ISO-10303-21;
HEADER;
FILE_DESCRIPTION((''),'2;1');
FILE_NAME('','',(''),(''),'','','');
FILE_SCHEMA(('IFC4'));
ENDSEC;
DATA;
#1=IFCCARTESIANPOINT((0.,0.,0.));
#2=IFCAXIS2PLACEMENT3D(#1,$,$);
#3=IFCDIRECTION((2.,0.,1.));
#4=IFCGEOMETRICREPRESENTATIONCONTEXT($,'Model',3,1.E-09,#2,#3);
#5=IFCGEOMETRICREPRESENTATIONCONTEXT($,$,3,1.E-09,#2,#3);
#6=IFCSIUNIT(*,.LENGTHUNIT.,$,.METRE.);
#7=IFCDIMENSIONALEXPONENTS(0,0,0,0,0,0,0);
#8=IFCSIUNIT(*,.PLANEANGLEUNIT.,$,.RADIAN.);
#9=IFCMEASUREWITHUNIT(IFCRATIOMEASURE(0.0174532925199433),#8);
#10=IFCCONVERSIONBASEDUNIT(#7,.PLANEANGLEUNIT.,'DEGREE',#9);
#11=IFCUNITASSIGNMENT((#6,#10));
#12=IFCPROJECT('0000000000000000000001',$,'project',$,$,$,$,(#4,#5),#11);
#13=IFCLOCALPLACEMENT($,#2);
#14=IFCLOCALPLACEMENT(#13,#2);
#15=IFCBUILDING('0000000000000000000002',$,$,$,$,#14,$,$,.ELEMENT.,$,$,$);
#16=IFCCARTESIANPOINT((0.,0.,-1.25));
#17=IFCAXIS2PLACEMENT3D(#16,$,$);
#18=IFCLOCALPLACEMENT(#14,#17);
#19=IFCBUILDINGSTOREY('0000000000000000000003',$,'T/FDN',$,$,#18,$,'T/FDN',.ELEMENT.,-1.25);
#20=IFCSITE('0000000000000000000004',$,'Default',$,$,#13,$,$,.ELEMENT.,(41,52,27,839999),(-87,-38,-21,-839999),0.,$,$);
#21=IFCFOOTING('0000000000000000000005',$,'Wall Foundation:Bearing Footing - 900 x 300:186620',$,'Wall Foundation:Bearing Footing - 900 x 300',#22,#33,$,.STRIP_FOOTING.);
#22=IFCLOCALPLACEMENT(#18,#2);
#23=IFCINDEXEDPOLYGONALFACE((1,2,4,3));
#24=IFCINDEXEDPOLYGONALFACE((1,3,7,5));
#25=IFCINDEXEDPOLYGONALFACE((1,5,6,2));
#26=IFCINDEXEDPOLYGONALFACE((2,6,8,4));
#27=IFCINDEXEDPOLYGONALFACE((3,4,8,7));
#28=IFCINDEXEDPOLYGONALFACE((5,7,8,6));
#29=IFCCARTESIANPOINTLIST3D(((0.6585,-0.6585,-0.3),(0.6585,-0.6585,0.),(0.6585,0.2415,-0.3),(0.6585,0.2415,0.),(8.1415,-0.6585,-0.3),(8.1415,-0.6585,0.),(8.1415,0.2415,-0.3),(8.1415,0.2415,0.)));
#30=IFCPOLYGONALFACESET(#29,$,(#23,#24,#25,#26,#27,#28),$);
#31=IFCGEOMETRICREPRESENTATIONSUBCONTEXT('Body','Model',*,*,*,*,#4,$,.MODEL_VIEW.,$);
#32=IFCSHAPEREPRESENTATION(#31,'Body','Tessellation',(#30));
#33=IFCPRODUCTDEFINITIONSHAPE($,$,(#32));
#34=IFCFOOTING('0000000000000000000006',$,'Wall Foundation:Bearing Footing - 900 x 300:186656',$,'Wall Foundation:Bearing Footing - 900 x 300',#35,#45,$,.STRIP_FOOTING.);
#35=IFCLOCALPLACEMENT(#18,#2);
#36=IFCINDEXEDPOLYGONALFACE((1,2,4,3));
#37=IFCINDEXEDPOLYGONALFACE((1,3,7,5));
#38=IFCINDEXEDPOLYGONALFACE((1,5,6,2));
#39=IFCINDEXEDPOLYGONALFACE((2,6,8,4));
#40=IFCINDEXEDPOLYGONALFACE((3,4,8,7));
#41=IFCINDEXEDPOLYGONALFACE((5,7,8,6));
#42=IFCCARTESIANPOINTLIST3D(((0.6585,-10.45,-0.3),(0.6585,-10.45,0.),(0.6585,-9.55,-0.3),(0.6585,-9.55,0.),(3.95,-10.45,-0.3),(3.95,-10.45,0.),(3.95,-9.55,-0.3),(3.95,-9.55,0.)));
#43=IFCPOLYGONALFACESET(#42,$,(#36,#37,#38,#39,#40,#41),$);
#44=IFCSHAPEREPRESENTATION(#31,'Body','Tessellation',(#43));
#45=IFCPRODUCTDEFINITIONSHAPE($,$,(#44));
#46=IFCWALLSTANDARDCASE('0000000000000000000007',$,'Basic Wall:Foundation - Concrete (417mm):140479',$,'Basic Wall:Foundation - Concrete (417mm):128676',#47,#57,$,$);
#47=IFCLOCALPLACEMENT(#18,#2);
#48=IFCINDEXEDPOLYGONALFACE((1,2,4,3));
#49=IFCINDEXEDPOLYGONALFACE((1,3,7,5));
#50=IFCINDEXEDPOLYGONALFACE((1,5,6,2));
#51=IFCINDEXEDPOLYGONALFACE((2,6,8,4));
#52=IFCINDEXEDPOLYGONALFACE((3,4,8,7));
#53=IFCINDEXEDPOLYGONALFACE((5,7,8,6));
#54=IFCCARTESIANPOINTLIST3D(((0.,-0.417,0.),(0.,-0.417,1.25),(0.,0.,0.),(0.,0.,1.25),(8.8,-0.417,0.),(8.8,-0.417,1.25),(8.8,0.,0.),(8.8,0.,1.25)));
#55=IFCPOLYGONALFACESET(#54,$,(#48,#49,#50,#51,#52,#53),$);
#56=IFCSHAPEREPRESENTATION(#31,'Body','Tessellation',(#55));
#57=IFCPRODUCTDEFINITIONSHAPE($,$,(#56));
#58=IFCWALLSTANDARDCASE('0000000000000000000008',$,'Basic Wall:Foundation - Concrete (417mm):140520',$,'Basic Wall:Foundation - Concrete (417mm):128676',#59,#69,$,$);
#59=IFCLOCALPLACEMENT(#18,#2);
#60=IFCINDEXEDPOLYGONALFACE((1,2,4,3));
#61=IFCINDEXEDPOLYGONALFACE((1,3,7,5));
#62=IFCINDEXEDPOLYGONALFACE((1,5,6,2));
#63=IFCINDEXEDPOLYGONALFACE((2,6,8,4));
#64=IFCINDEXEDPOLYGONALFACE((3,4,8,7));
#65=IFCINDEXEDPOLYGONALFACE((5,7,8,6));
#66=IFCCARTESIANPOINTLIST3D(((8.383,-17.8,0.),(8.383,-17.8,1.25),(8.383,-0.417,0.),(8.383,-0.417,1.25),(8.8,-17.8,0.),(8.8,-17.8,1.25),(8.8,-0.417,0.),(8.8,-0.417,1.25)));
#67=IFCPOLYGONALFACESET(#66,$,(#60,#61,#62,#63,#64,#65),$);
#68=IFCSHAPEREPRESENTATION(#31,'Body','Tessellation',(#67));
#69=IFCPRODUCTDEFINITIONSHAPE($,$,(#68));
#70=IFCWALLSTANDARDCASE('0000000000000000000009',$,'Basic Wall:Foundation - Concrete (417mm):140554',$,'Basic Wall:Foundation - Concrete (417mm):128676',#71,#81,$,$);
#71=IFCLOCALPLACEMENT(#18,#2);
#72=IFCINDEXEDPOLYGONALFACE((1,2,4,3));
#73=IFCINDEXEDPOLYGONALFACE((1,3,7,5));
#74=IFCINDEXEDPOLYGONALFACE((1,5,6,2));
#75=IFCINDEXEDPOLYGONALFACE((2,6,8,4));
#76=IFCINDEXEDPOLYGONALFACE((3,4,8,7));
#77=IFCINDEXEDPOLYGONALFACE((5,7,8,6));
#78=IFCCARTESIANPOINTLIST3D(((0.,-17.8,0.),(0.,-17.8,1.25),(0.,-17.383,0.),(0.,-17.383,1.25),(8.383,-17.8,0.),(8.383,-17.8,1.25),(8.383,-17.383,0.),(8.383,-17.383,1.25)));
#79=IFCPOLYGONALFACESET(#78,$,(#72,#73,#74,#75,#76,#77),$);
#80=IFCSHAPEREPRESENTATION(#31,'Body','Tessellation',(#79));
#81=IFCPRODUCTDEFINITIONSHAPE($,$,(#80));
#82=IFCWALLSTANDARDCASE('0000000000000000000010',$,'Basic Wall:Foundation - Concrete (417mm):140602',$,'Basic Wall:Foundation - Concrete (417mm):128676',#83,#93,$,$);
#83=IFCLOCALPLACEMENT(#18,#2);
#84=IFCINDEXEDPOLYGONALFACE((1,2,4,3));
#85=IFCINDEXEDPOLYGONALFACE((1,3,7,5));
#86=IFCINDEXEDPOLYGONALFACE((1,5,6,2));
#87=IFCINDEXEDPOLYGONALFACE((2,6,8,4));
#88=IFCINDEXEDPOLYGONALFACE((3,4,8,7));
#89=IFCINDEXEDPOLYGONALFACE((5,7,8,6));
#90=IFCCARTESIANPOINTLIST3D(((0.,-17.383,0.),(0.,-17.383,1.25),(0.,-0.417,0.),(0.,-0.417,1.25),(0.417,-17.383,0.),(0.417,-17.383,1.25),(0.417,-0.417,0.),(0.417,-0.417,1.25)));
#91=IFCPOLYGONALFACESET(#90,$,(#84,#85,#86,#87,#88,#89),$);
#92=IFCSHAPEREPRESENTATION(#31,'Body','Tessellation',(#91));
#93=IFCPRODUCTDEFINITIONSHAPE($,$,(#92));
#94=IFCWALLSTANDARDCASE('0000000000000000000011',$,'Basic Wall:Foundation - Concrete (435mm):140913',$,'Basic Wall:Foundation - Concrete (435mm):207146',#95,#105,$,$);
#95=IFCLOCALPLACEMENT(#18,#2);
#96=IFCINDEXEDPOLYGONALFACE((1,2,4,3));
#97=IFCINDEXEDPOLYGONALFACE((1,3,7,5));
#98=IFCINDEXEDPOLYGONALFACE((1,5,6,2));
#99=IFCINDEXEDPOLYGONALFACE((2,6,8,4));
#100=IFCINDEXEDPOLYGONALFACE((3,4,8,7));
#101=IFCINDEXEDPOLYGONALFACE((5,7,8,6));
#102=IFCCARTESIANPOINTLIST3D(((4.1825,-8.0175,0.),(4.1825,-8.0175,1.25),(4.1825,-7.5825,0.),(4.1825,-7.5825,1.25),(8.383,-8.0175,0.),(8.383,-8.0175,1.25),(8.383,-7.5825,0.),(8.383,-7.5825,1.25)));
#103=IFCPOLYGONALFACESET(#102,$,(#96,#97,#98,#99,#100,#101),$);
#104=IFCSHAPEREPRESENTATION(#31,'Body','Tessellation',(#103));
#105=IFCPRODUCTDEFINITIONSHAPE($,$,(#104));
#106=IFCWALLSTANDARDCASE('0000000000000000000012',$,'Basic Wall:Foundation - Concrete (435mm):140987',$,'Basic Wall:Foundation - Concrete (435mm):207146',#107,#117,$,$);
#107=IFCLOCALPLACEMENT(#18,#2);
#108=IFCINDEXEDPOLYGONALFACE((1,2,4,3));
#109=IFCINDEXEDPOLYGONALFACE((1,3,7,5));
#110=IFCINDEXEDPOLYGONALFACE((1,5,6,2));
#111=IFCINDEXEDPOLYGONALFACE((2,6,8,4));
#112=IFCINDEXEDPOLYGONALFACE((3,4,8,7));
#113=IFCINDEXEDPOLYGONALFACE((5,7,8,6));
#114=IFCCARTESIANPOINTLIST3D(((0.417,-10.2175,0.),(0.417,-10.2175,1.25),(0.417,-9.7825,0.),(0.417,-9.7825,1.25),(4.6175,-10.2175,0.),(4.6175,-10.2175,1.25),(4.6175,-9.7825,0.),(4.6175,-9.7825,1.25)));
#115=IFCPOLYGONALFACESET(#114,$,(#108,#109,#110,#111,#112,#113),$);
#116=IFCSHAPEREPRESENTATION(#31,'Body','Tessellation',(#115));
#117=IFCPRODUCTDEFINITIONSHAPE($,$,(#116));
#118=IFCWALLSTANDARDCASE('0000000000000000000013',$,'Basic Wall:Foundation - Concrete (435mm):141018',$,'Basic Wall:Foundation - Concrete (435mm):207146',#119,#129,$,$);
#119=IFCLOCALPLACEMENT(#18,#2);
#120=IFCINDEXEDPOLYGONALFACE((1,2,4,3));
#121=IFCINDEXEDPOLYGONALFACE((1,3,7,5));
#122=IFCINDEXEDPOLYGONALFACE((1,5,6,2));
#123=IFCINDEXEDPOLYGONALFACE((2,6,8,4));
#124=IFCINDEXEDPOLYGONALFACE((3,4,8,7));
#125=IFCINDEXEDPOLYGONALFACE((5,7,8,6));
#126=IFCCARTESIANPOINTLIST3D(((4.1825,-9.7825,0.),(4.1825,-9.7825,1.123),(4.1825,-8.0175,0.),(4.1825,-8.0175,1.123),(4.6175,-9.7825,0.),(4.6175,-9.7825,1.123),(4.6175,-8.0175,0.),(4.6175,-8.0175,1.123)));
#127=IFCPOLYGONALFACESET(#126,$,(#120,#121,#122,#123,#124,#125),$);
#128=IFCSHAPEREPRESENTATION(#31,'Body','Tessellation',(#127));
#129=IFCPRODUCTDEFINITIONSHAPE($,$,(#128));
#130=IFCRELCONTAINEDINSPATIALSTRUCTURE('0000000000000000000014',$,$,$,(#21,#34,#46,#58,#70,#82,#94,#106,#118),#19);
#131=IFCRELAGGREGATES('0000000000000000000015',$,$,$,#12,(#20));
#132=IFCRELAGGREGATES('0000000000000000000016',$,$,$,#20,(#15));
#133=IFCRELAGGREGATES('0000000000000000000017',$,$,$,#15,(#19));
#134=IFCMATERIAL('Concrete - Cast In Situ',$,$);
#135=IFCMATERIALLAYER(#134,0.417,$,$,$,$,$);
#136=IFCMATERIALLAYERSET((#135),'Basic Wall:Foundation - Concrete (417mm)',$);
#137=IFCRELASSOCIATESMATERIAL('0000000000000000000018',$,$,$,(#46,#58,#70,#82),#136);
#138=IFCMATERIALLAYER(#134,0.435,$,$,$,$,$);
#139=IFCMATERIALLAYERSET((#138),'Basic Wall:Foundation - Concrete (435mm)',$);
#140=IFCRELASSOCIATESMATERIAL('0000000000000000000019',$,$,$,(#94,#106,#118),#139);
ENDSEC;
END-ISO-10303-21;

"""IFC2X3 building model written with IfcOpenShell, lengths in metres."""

from ifc_helpers import new_model, entity, si_unit, converted_unit, direction, frame, frame_2d, origin, place, context, subcontext, project, spatial, rectangle, extrude, material, layer, layer_set, layer_usage, element, save


model = new_model("IFC2X3")

# Units and contexts
model_context = context("Model", 3, precision=1e-09, world=origin(), true_north=direction((2.0, 0.0, 1.0)))
context_of_model = context(None, 3, precision=1e-09, world=origin(), true_north=direction((2.0, 0.0, 1.0)))
body_context = subcontext(model_context, "Body", "Model", "MODEL_VIEW")
ifc_project = project(units=[si_unit("LENGTHUNIT", "METRE"), converted_unit("PLANEANGLEUNIT", "DEGREE", entity("IfcRatioMeasure", 0.0174532925199433), si_unit("PLANEANGLEUNIT", "RADIAN"), dimensions=[0, 0, 0, 0, 0, 0, 0])], contexts=[model_context, context_of_model])

# Site, building, storey
site_placement = place(None, origin())
site = spatial("IfcSite", under=ifc_project, at=site_placement, Name="Default", CompositionType="ELEMENT", RefLatitude=(41, 52, 27, 839999), RefLongitude=(-87, -38, -21, -839999), RefElevation=0.0)
building_placement = place(site_placement, origin())
building = spatial("IfcBuilding", under=site, at=building_placement, CompositionType="ELEMENT")
storey_placement = place(building_placement, frame((0.0, 0.0, -1.25)))
storey = spatial("IfcBuildingStorey", under=building, at=storey_placement, Name="T/FDN", LongName="T/FDN", CompositionType="ELEMENT", Elevation=-1.25)

# Footings
footing_1_placement = place(storey_placement, origin())
element("IfcFooting", 1, at=footing_1_placement, inside=storey, Name="Wall Foundation:Bearing Footing - 900 x 300:186620", ObjectType="Wall Foundation:Bearing Footing - 900 x 300", PredefinedType="STRIP_FOOTING", context=body_context, shape_type="SweptSolid", body=[
    extrude(rectangle(XDim=7.483, YDim=0.9, at=frame_2d((0.0, 0.0), x_axis=(1.0, 0.0))), frame((4.4, -0.2085, -0.3), z_axis=(0.0, 0.0, 1.0), x_axis=(-1.0, 0.0, 0.0)), (0.0, 0.0, 1.0), 0.3),
])
footing_2_placement = place(storey_placement, origin())
element("IfcFooting", 2, at=footing_2_placement, inside=storey, Name="Wall Foundation:Bearing Footing - 900 x 300:186656", ObjectType="Wall Foundation:Bearing Footing - 900 x 300", PredefinedType="STRIP_FOOTING", context=body_context, shape_type="SweptSolid", body=[
    extrude(rectangle(XDim=3.2915, YDim=0.9, at=frame_2d((0.0, 0.0), x_axis=(1.0, 0.0))), frame((2.3043, -10.0, -0.3)), (0.0, 0.0, 1.0), 0.3),
])

# Walls
ifc_material = material(Name="Concrete - Cast In Situ")
ifc_layer_1 = layer(ifc_material, 0.417)
ifc_layer_set_1 = layer_set([ifc_layer_1], Name="Basic Wall:Foundation - Concrete (417mm)")
ifc_layer_usage_1 = layer_usage(ifc_layer_set_1, "AXIS2", "NEGATIVE", 0.2085)
wall_1_placement = place(storey_placement, frame((0.0, -0.2085, 0.0)))
element("IfcWallStandardCase", 3, at=wall_1_placement, inside=storey, material=ifc_layer_usage_1, Name="Basic Wall:Foundation - Concrete (417mm):140479", ObjectType="Basic Wall:Foundation - Concrete (417mm):128676", context=body_context, shape_type="SweptSolid", body=[
    extrude(rectangle(XDim=8.8, YDim=0.417, at=frame_2d((4.4, 0.0), x_axis=(-1.0, 0.0))), origin(), (0.0, 0.0, 1.0), 1.25),
])
ifc_layer_usage_2 = layer_usage(ifc_layer_set_1, "AXIS2", "NEGATIVE", 0.2085)
wall_2_placement = place(storey_placement, frame((8.5915, -0.417, 0.0), z_axis=(0.0, 0.0, 1.0), x_axis=(0.0, -1.0, 0.0)))
element("IfcWallStandardCase", 4, at=wall_2_placement, inside=storey, material=ifc_layer_usage_2, Name="Basic Wall:Foundation - Concrete (417mm):140520", ObjectType="Basic Wall:Foundation - Concrete (417mm):128676", context=body_context, shape_type="SweptSolid", body=[
    extrude(rectangle(XDim=17.383, YDim=0.417, at=frame_2d((8.6915, 0.0), x_axis=(-1.0, 0.0))), origin(), (0.0, 0.0, 1.0), 1.25),
])
ifc_layer_usage_3 = layer_usage(ifc_layer_set_1, "AXIS2", "NEGATIVE", 0.2085)
wall_3_placement = place(storey_placement, frame((8.383, -17.5915, 0.0), z_axis=(0.0, 0.0, 1.0), x_axis=(-1.0, 0.0, 0.0)))
element("IfcWallStandardCase", 5, at=wall_3_placement, inside=storey, material=ifc_layer_usage_3, Name="Basic Wall:Foundation - Concrete (417mm):140554", ObjectType="Basic Wall:Foundation - Concrete (417mm):128676", context=body_context, shape_type="SweptSolid", body=[
    extrude(rectangle(XDim=8.383, YDim=0.417, at=frame_2d((4.1915, 0.0), x_axis=(-1.0, 0.0))), origin(), (0.0, 0.0, 1.0), 1.25),
])
ifc_layer_usage_4 = layer_usage(ifc_layer_set_1, "AXIS2", "NEGATIVE", 0.2085)
wall_4_placement = place(storey_placement, frame((0.2085, -17.383, 0.0), z_axis=(0.0, 0.0, 1.0), x_axis=(0.0, 1.0, 0.0)))
element("IfcWallStandardCase", 6, at=wall_4_placement, inside=storey, material=ifc_layer_usage_4, Name="Basic Wall:Foundation - Concrete (417mm):140602", ObjectType="Basic Wall:Foundation - Concrete (417mm):128676", context=body_context, shape_type="SweptSolid", body=[
    extrude(rectangle(XDim=16.966, YDim=0.417, at=frame_2d((8.483, 0.0), x_axis=(-1.0, 0.0))), origin(), (0.0, 0.0, 1.0), 1.25),
])
ifc_layer_2 = layer(ifc_material, 0.435)
ifc_layer_set_2 = layer_set([ifc_layer_2], Name="Basic Wall:Foundation - Concrete (435mm)")
ifc_layer_usage_5 = layer_usage(ifc_layer_set_2, "AXIS2", "NEGATIVE", 0.2175)
wall_5_placement = place(storey_placement, frame((8.383, -7.8, 0.0), z_axis=(0.0, 0.0, 1.0), x_axis=(-1.0, 0.0, 0.0)))
element("IfcWallStandardCase", 7, at=wall_5_placement, inside=storey, material=ifc_layer_usage_5, Name="Basic Wall:Foundation - Concrete (435mm):140913", ObjectType="Basic Wall:Foundation - Concrete (435mm):207146", context=body_context, shape_type="SweptSolid", body=[
    extrude(rectangle(XDim=4.2005, YDim=0.435, at=frame_2d((2.1002, 0.0), x_axis=(-1.0, 0.0))), origin(), (0.0, 0.0, 1.0), 1.25),
])
ifc_layer_usage_6 = layer_usage(ifc_layer_set_2, "AXIS2", "NEGATIVE", 0.2175)
wall_6_placement = place(storey_placement, frame((0.417, -10.0, 0.0)))
element("IfcWallStandardCase", 8, at=wall_6_placement, inside=storey, material=ifc_layer_usage_6, Name="Basic Wall:Foundation - Concrete (435mm):140987", ObjectType="Basic Wall:Foundation - Concrete (435mm):207146", context=body_context, shape_type="SweptSolid", body=[
    extrude(rectangle(XDim=4.2005, YDim=0.435, at=frame_2d((2.1002, 0.0), x_axis=(-1.0, 0.0))), origin(), (0.0, 0.0, 1.0), 1.25),
])
ifc_layer_usage_7 = layer_usage(ifc_layer_set_2, "AXIS2", "NEGATIVE", 0.2175)
wall_7_placement = place(storey_placement, frame((4.4, -9.7825, 0.0), z_axis=(0.0, 0.0, 1.0), x_axis=(0.0, 1.0, 0.0)))
element("IfcWallStandardCase", 9, at=wall_7_placement, inside=storey, material=ifc_layer_usage_7, Name="Basic Wall:Foundation - Concrete (435mm):141018", ObjectType="Basic Wall:Foundation - Concrete (435mm):207146", context=body_context, shape_type="SweptSolid", body=[
    extrude(rectangle(XDim=1.765, YDim=0.435, at=frame_2d((0.8825, 0.0), x_axis=(-1.0, 0.0))), origin(), (0.0, 0.0, 1.0), 1.123),
])

save(model, "model.ifc")
